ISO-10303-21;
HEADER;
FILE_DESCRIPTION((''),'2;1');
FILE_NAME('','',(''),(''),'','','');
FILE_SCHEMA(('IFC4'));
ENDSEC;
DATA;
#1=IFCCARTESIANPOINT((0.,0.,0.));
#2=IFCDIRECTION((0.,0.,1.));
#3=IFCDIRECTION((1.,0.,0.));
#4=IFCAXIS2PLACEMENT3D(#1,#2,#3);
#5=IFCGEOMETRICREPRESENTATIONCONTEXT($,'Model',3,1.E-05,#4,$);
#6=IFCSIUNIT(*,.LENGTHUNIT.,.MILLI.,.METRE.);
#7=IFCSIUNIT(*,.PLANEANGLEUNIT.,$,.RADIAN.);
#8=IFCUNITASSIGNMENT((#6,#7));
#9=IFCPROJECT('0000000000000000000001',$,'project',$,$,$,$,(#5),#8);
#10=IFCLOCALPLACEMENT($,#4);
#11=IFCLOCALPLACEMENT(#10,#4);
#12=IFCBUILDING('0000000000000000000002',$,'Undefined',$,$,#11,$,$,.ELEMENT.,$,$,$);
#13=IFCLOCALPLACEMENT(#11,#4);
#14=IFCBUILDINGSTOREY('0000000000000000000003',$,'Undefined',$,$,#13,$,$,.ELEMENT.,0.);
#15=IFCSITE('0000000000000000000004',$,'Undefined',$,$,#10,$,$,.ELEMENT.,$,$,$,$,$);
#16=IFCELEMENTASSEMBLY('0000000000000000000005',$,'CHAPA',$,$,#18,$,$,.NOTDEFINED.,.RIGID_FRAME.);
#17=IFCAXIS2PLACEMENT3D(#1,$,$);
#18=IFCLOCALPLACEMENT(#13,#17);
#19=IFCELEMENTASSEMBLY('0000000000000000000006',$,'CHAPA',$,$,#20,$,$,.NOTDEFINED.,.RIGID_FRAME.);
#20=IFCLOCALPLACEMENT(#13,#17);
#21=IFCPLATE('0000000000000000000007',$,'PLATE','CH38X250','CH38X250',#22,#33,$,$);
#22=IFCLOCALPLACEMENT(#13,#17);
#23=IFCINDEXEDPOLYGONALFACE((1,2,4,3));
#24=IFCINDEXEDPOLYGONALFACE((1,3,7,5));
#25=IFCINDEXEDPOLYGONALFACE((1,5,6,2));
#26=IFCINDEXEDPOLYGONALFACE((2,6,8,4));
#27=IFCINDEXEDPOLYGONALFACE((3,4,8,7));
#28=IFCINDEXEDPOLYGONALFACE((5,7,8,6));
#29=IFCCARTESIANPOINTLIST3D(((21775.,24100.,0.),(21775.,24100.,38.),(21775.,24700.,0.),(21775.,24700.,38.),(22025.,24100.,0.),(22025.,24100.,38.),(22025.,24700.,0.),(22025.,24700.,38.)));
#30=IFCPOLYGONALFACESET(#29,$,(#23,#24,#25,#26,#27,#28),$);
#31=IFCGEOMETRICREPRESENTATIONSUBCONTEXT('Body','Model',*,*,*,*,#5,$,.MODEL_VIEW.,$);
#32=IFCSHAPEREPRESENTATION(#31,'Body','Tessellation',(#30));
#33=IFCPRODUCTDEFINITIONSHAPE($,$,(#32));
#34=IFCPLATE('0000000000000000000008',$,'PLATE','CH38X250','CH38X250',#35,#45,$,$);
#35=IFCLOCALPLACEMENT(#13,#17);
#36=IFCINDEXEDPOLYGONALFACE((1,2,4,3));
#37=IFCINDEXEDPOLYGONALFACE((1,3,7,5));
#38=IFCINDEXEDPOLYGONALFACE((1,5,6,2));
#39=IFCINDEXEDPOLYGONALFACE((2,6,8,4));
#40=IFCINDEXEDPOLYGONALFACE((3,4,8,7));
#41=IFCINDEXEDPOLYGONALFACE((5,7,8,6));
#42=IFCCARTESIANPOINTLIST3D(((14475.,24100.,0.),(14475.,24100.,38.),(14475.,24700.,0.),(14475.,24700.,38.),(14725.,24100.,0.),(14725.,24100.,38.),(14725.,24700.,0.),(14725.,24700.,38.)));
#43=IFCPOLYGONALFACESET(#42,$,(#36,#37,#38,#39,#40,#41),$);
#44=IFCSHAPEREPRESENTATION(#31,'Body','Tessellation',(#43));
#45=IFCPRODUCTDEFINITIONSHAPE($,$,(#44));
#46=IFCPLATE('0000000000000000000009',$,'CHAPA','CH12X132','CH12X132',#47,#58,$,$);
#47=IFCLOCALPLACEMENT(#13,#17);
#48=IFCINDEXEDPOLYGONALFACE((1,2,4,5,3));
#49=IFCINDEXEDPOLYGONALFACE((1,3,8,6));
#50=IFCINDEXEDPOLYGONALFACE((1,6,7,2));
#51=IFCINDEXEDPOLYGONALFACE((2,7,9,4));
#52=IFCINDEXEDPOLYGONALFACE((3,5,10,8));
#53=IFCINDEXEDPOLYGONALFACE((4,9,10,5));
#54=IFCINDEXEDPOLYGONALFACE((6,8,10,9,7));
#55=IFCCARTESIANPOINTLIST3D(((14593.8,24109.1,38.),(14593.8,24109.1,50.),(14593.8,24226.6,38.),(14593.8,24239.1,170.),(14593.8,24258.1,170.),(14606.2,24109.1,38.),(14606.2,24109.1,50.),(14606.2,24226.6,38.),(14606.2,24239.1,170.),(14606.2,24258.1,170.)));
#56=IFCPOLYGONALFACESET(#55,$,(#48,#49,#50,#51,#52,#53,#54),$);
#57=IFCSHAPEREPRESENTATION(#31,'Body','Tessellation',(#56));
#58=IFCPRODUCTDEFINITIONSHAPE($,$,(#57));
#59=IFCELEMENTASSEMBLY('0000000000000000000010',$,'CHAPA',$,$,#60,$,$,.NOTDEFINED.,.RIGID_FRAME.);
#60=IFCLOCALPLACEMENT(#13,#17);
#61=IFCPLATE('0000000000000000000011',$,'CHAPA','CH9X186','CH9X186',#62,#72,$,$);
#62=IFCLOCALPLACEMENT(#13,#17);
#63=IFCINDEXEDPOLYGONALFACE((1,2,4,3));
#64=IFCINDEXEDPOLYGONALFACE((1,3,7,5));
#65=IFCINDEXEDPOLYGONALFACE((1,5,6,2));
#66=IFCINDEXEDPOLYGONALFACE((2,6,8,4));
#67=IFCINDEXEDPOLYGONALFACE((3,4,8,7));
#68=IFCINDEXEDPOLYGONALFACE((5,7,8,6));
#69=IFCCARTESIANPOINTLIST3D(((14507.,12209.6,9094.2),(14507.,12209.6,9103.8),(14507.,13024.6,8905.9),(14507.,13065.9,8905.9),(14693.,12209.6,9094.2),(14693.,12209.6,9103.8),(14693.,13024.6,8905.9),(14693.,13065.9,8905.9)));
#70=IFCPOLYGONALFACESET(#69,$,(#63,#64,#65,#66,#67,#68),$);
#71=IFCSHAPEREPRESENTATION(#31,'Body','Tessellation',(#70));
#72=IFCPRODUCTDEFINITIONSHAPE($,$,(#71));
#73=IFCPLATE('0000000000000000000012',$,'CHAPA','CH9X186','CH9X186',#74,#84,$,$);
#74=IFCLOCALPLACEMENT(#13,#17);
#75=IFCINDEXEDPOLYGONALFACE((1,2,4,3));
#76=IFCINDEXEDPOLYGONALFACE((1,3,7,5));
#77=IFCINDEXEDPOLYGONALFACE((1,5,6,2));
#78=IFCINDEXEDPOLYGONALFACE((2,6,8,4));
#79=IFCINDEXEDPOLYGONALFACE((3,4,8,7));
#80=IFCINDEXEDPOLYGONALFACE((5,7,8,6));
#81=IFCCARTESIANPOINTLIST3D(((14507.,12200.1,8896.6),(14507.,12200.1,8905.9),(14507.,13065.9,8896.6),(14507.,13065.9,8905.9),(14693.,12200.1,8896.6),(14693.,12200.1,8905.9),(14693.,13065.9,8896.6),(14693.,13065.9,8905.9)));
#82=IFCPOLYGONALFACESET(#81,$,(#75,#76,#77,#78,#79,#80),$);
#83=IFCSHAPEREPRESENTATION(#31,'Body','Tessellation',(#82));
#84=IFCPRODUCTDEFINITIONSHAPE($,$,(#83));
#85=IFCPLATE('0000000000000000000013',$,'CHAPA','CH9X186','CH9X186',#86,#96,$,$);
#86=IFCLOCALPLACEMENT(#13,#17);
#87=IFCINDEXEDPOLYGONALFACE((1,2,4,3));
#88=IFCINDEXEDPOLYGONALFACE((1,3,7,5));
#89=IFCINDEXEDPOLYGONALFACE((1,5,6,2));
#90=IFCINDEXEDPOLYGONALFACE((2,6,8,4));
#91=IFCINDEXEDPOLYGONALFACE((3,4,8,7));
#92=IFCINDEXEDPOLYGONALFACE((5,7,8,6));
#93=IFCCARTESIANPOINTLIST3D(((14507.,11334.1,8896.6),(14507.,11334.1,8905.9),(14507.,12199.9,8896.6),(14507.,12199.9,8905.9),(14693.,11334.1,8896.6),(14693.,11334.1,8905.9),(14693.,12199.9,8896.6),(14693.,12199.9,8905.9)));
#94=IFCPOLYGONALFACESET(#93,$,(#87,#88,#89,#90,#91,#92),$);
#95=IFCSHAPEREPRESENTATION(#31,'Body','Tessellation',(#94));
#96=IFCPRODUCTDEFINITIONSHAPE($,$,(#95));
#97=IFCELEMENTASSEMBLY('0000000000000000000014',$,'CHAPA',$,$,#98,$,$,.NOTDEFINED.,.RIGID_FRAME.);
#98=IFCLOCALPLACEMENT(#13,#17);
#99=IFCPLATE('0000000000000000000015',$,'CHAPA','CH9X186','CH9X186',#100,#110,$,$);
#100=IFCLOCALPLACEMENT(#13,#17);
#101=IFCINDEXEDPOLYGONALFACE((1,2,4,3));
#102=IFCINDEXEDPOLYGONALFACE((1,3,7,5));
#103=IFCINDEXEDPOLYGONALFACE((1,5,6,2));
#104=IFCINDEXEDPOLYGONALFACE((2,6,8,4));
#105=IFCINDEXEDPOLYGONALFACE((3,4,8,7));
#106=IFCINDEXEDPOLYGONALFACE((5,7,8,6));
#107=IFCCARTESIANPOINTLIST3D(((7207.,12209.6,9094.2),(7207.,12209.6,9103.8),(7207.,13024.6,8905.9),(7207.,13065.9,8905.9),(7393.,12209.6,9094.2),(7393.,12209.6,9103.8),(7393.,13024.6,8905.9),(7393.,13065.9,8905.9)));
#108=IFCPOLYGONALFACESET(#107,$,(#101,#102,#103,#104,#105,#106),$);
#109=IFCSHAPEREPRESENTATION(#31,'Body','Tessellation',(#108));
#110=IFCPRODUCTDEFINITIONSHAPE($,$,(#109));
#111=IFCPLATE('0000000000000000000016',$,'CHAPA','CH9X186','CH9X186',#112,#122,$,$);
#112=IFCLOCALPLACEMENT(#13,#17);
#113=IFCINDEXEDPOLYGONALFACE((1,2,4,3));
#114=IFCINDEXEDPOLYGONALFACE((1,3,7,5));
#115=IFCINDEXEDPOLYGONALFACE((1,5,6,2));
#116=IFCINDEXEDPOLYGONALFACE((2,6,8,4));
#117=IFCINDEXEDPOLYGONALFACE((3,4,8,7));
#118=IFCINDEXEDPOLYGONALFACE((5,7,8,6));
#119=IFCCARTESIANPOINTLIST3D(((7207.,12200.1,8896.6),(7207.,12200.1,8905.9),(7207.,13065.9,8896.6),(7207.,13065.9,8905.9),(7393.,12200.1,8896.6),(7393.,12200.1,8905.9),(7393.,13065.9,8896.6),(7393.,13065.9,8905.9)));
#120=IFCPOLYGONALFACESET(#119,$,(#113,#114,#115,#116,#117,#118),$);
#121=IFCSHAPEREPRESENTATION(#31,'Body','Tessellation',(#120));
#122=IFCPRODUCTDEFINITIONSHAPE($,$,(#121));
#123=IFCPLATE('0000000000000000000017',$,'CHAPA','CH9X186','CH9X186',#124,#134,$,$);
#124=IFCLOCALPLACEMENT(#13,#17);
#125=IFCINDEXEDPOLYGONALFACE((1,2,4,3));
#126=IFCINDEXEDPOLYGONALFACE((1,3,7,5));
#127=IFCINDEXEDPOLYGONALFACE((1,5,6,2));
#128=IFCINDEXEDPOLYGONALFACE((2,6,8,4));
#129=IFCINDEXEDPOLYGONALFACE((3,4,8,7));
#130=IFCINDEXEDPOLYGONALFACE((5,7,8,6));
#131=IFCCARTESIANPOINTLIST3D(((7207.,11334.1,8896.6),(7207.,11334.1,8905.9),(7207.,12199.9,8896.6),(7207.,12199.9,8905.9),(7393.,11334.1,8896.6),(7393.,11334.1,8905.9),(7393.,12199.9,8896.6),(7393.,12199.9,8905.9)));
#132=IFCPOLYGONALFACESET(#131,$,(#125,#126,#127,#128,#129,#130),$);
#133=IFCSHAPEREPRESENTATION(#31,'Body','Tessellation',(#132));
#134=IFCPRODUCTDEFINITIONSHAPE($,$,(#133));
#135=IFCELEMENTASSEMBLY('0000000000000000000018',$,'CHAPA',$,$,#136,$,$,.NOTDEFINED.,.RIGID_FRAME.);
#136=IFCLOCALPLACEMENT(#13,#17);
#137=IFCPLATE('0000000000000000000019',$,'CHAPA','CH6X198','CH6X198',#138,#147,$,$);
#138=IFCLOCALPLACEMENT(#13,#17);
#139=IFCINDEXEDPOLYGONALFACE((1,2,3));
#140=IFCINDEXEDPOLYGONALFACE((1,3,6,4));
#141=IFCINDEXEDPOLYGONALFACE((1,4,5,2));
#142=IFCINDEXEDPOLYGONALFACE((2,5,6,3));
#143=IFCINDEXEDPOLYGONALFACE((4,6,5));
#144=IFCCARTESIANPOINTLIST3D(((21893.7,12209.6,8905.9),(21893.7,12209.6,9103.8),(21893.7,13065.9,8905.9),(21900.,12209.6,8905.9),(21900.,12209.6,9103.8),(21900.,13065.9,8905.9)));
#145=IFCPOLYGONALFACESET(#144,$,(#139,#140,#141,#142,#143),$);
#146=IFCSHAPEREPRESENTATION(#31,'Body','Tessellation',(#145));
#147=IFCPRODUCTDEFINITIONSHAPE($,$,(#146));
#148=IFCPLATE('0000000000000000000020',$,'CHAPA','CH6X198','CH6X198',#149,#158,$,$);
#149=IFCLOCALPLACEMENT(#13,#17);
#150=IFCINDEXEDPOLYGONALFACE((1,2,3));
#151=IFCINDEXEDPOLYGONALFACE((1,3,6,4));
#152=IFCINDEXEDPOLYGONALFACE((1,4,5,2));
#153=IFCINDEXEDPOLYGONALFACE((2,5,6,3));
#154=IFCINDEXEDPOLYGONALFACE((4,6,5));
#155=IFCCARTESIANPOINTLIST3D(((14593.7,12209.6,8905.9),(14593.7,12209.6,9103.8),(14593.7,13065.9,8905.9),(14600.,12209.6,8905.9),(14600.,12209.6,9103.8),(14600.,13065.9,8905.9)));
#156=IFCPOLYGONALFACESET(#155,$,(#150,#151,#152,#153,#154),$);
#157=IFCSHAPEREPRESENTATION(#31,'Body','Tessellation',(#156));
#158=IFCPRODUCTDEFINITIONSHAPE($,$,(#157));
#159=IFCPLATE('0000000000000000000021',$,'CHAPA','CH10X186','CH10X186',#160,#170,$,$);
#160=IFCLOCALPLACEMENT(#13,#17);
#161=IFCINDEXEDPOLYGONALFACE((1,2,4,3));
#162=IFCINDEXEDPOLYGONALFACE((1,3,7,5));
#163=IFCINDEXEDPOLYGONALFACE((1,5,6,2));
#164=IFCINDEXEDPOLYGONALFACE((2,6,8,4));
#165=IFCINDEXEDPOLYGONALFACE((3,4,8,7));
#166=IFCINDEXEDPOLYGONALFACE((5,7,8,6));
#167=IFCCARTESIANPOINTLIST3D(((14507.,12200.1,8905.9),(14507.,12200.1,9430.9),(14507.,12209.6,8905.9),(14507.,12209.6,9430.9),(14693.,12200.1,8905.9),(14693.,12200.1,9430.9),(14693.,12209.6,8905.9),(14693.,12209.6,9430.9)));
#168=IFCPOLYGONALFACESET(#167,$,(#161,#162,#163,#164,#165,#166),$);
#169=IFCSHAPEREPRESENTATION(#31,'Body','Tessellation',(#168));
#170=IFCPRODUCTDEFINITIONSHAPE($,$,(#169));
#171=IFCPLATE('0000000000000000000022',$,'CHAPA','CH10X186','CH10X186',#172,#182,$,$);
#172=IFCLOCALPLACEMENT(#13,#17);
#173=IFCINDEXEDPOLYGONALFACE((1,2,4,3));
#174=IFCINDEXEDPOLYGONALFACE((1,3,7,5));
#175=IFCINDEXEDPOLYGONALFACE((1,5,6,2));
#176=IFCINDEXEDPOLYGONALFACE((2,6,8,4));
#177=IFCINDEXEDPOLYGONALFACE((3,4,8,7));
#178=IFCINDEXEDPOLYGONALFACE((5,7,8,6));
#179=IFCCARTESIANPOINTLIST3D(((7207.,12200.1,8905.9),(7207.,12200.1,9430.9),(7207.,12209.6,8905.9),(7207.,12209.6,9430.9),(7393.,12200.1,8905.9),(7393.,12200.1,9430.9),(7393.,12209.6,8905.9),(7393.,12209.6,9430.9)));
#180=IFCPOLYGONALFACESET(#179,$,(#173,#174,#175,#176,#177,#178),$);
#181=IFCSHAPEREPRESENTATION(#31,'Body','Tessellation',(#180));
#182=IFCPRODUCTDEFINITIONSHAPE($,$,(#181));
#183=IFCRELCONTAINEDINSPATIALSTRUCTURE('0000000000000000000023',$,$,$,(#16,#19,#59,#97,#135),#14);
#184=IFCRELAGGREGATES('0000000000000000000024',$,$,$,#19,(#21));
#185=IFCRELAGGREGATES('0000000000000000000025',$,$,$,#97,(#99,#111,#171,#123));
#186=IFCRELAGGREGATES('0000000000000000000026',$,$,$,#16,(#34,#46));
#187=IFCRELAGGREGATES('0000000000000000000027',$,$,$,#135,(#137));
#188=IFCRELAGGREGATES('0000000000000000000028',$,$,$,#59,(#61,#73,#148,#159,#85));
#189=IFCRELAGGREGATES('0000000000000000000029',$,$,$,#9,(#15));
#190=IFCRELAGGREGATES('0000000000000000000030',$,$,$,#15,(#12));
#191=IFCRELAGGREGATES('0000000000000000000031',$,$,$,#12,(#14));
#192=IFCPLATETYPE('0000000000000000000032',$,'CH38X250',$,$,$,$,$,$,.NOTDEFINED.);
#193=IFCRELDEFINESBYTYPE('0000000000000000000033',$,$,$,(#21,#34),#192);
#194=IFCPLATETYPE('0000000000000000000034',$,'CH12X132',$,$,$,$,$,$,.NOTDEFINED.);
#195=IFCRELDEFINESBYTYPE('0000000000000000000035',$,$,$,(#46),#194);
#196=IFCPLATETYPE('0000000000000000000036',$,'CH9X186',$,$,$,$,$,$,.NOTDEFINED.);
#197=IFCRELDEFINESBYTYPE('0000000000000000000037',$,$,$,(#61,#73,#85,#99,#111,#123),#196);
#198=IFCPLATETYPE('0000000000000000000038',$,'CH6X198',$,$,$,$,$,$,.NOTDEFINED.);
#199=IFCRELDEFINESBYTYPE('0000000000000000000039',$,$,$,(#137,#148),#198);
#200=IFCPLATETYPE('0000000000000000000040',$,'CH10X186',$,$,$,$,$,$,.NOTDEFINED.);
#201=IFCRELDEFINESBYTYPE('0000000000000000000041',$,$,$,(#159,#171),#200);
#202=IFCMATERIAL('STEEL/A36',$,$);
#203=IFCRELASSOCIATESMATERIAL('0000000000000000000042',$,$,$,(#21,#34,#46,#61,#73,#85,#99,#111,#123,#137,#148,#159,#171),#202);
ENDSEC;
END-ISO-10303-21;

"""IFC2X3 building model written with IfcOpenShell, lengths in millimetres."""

from ifc_helpers import new_model, si_unit, frame, origin_with_axes, place, context, subcontext, project, spatial, polyline, outline, extrude, clip, halfspace, material, type_object, element, aggregate, save


model = new_model("IFC2X3")

# Units and contexts
model_context = context("Model", 3, precision=1e-05, world=origin_with_axes())
body_context = subcontext(model_context, "Body", "Model", "MODEL_VIEW")
ifc_project = project(units=[si_unit("LENGTHUNIT", "METRE", prefix="MILLI"), si_unit("PLANEANGLEUNIT", "RADIAN")], contexts=[model_context])

# Site, building, storey
site_placement = place(None, origin_with_axes())
site = spatial("IfcSite", under=ifc_project, at=site_placement, Name="Undefined", CompositionType="ELEMENT")
building_placement = place(site_placement, origin_with_axes())
building = spatial("IfcBuilding", under=site, at=building_placement, Name="Undefined", CompositionType="ELEMENT")
storey_placement = place(building_placement, origin_with_axes())
storey = spatial("IfcBuildingStorey", under=building, at=storey_placement, Name="Undefined", CompositionType="ELEMENT", Elevation=0.0)

# Element assembly
assembly_1_placement = place(storey_placement, origin_with_axes())
assembly_1 = element("IfcElementAssembly", 1, at=assembly_1_placement, inside=storey, Name="CHAPA", AssemblyPlace="NOTDEFINED", PredefinedType="RIGID_FRAME")

# Element assembly, plate
assembly_2_placement = place(storey_placement, origin_with_axes())
assembly_2 = element("IfcElementAssembly", 2, at=assembly_2_placement, inside=storey, Name="CHAPA", AssemblyPlace="NOTDEFINED", PredefinedType="RIGID_FRAME")
ifc_material_1 = material(Name="STEEL/A36")
plate_type_1 = type_object("IfcPlateType", Name="CH38X250", PredefinedType="NOTDEFINED")
plate_1_placement = place(assembly_2_placement, frame((21775.0, 24700.0, 19.0), z_axis=(0.0, 0.0, 1.0), x_axis=(0.0, -1.0, 0.0)))
plate_1 = element("IfcPlate", 3, at=plate_1_placement, type_object=plate_type_1, material=ifc_material_1, Name="PLATE", Description="CH38X250", ObjectType="CH38X250", context=body_context, shape_type="SweptSolid", body=[
    extrude(outline(polyline([(0.0, 0.0), (600.0, 0.0), (600.0, 250.0), (0.0, 250.0), (0.0, 0.0)])), frame((0.0, 0.0, -19.0), z_axis=(0.0, 0.0, 1.0), x_axis=(1.0, 0.0, 0.0)), (0.0, 0.0, 1.0), 38.0),
])
aggregate(assembly_2, [plate_1])

# Plates
plate_2_placement = place(assembly_1_placement, frame((14475.0, 24700.0, 19.0), z_axis=(0.0, 0.0, 1.0), x_axis=(0.0, -1.0, 0.0)))
plate_2 = element("IfcPlate", 4, at=plate_2_placement, type_object=plate_type_1, material=ifc_material_1, Name="PLATE", Description="CH38X250", ObjectType="CH38X250", context=body_context, shape_type="SweptSolid", body=[
    extrude(outline(polyline([(0.0, 0.0), (600.0, 0.0), (600.0, 250.0), (0.0, 250.0), (0.0, 0.0)])), frame((0.0, 0.0, -19.0), z_axis=(0.0, 0.0, 1.0), x_axis=(1.0, 0.0, 0.0)), (0.0, 0.0, 1.0), 38.0),
])
plate_type_2 = type_object("IfcPlateType", Name="CH12X132", PredefinedType="NOTDEFINED")
plate_3_placement = place(assembly_1_placement, frame((14600.0, 24226.6, 38.0), z_axis=(-1.0, 0.0, 0.0), x_axis=(0.0, -1.0, 0.0)))
plate_3 = element("IfcPlate", 5, at=plate_3_placement, type_object=plate_type_2, material=ifc_material_1, Name="CHAPA", Description="CH12X132", ObjectType="CH12X132", context=body_context, shape_type="SweptSolid", body=[
    extrude(outline(polyline([(0.0, 0.0), (117.5, 0.0), (117.5, 12.0), (-12.5, 132.0), (-31.6, 132.0), (0.0, 0.0)])), frame((0.0, 0.0, -6.2), z_axis=(0.0, 0.0, 1.0), x_axis=(1.0, 0.0, 0.0)), (0.0, 0.0, 1.0), 12.5),
])

# Element assemblies, plates
assembly_3_placement = place(storey_placement, origin_with_axes())
assembly_3 = element("IfcElementAssembly", 6, at=assembly_3_placement, inside=storey, Name="CHAPA", AssemblyPlace="NOTDEFINED", PredefinedType="RIGID_FRAME")
plate_type_3 = type_object("IfcPlateType", Name="CH9X186", PredefinedType="NOTDEFINED")
plate_4_placement = place(assembly_3_placement, frame((14693.0, 12208.6, 9099.3), z_axis=(0.0, -0.225125, -0.97433), x_axis=(-1.0, 0.0, 0.0)))
plate_4 = element("IfcPlate", 7, at=plate_4_placement, type_object=plate_type_3, material=ifc_material_1, Name="CHAPA", Description="CH9X186", ObjectType="CH9X186", context=body_context, shape_type="Clipping", body=[
    clip(clip(extrude(outline(polyline([(0.0, 0.0), (186.0, 0.0), (186.0, 878.9), (0.0, 878.9), (0.0, 0.0)])), frame((0.0, 0.0, -4.7), z_axis=(0.0, 0.0, 1.0), x_axis=(1.0, 0.0, 0.0)), (0.0, 0.0, 1.0), 9.3), halfspace(frame((186.0, -500.0, 314.0), z_axis=(0.0, 0.225128, 0.974329), x_axis=(-1.0, 0.0, 0.0)), False)), halfspace(frame((0.0, 2.1, 4.7), z_axis=(0.0, -0.97433, 0.225125), x_axis=(1.0, 0.0, 0.0)), False)),
])
plate_5_placement = place(assembly_3_placement, frame((14693.0, 12200.1, 8901.3), z_axis=(0.0, 0.0, -1.0), x_axis=(-1.0, 0.0, 0.0)))
plate_5 = element("IfcPlate", 8, at=plate_5_placement, type_object=plate_type_3, material=ifc_material_1, Name="CHAPA", Description="CH9X186", ObjectType="CH9X186", context=body_context, shape_type="SweptSolid", body=[
    extrude(outline(polyline([(0.0, 0.0), (186.0, 0.0), (186.0, 865.8), (0.0, 865.8), (0.0, 0.0)])), frame((0.0, 0.0, -4.7), z_axis=(0.0, 0.0, 1.0), x_axis=(1.0, 0.0, 0.0)), (0.0, 0.0, 1.0), 9.3),
])
plate_6_placement = place(assembly_3_placement, frame((14693.0, 12199.9, 8901.3), z_axis=(0.0, 0.0, 1.0), x_axis=(-1.0, 0.0, 0.0)))
plate_6 = element("IfcPlate", 9, at=plate_6_placement, type_object=plate_type_3, material=ifc_material_1, Name="CHAPA", Description="CH9X186", ObjectType="CH9X186", context=body_context, shape_type="SweptSolid", body=[
    extrude(outline(polyline([(0.0, 0.0), (186.0, 0.0), (186.0, 865.8), (0.0, 865.8), (0.0, 0.0)])), frame((0.0, 0.0, -4.7), z_axis=(0.0, 0.0, 1.0), x_axis=(1.0, 0.0, 0.0)), (0.0, 0.0, 1.0), 9.3),
])
assembly_4_placement = place(storey_placement, origin_with_axes())
assembly_4 = element("IfcElementAssembly", 10, at=assembly_4_placement, inside=storey, Name="CHAPA", AssemblyPlace="NOTDEFINED", PredefinedType="RIGID_FRAME")
plate_7_placement = place(assembly_4_placement, frame((7393.0, 12208.6, 9099.3), z_axis=(0.0, -0.225125, -0.97433), x_axis=(-1.0, 0.0, 0.0)))
plate_7 = element("IfcPlate", 11, at=plate_7_placement, type_object=plate_type_3, material=ifc_material_1, Name="CHAPA", Description="CH9X186", ObjectType="CH9X186", context=body_context, shape_type="Clipping", body=[
    clip(clip(extrude(outline(polyline([(0.0, 0.0), (186.0, 0.0), (186.0, 878.9), (0.0, 878.9), (0.0, 0.0)])), frame((0.0, 0.0, -4.7), z_axis=(0.0, 0.0, 1.0), x_axis=(1.0, 0.0, 0.0)), (0.0, 0.0, 1.0), 9.3), halfspace(frame((186.0, -500.0, 314.0), z_axis=(0.0, 0.225128, 0.974329), x_axis=(-1.0, 0.0, 0.0)), False)), halfspace(frame((0.0, 2.1, 4.7), z_axis=(0.0, -0.97433, 0.225125), x_axis=(1.0, 0.0, 0.0)), False)),
])
plate_8_placement = place(assembly_4_placement, frame((7393.0, 12200.1, 8901.3), z_axis=(0.0, 0.0, -1.0), x_axis=(-1.0, 0.0, 0.0)))
plate_8 = element("IfcPlate", 12, at=plate_8_placement, type_object=plate_type_3, material=ifc_material_1, Name="CHAPA", Description="CH9X186", ObjectType="CH9X186", context=body_context, shape_type="SweptSolid", body=[
    extrude(outline(polyline([(0.0, 0.0), (186.0, 0.0), (186.0, 865.8), (0.0, 865.8), (0.0, 0.0)])), frame((0.0, 0.0, -4.7), z_axis=(0.0, 0.0, 1.0), x_axis=(1.0, 0.0, 0.0)), (0.0, 0.0, 1.0), 9.3),
])
plate_9_placement = place(assembly_4_placement, frame((7393.0, 12199.9, 8901.3), z_axis=(0.0, 0.0, 1.0), x_axis=(-1.0, 0.0, 0.0)))
plate_9 = element("IfcPlate", 13, at=plate_9_placement, type_object=plate_type_3, material=ifc_material_1, Name="CHAPA", Description="CH9X186", ObjectType="CH9X186", context=body_context, shape_type="SweptSolid", body=[
    extrude(outline(polyline([(0.0, 0.0), (186.0, 0.0), (186.0, 865.8), (0.0, 865.8), (0.0, 0.0)])), frame((0.0, 0.0, -4.7), z_axis=(0.0, 0.0, 1.0), x_axis=(1.0, 0.0, 0.0)), (0.0, 0.0, 1.0), 9.3),
])

# Element assembly, plate
assembly_5_placement = place(storey_placement, origin_with_axes())
assembly_5 = element("IfcElementAssembly", 14, at=assembly_5_placement, inside=storey, Name="CHAPA", AssemblyPlace="NOTDEFINED", PredefinedType="RIGID_FRAME")
plate_type_4 = type_object("IfcPlateType", Name="CH6X198", PredefinedType="NOTDEFINED")
plate_10_placement = place(assembly_5_placement, frame((21896.8, 13065.9, 8905.9), z_axis=(-1.0, 0.0, 0.0), x_axis=(0.0, -1.0, 0.0)))
plate_10 = element("IfcPlate", 15, at=plate_10_placement, type_object=plate_type_4, material=ifc_material_1, Name="CHAPA", Description="CH6X198", ObjectType="CH6X198", context=body_context, shape_type="SweptSolid", body=[
    extrude(outline(polyline([(0.0, 0.0), (856.3, 0.0), (856.3, 197.9), (0.0, 0.0)])), frame((0.0, 0.0, -3.1), z_axis=(0.0, 0.0, 1.0), x_axis=(1.0, 0.0, 0.0)), (0.0, 0.0, 1.0), 6.3),
])

# Plates
plate_11_placement = place(assembly_3_placement, frame((14596.9, 13065.9, 8905.9), z_axis=(-1.0, 0.0, 0.0), x_axis=(0.0, -1.0, 0.0)))
plate_11 = element("IfcPlate", 16, at=plate_11_placement, type_object=plate_type_4, material=ifc_material_1, Name="CHAPA", Description="CH6X198", ObjectType="CH6X198", context=body_context, shape_type="SweptSolid", body=[
    extrude(outline(polyline([(0.0, 0.0), (856.3, 0.0), (856.3, 197.9), (0.0, 0.0)])), frame((0.0, 0.0, -3.1), z_axis=(0.0, 0.0, 1.0), x_axis=(1.0, 0.0, 0.0)), (0.0, 0.0, 1.0), 6.3),
])
plate_type_5 = type_object("IfcPlateType", Name="CH10X186", PredefinedType="NOTDEFINED")
plate_12_placement = place(assembly_3_placement, frame((14693.0, 12204.8, 9430.9), z_axis=(0.0, -1.0, 0.0), x_axis=(-1.0, 0.0, 0.0)))
plate_12 = element("IfcPlate", 17, at=plate_12_placement, type_object=plate_type_5, material=ifc_material_1, Name="CHAPA", Description="CH10X186", ObjectType="CH10X186", context=body_context, shape_type="SweptSolid", body=[
    extrude(outline(polyline([(0.0, 0.0), (186.0, 0.0), (186.0, 525.0), (0.0, 525.0), (0.0, 0.0)])), frame((0.0, 0.0, -4.8), z_axis=(0.0, 0.0, 1.0), x_axis=(1.0, 0.0, 0.0)), (0.0, 0.0, 1.0), 9.5),
])
plate_13_placement = place(assembly_4_placement, frame((7393.0, 12204.8, 9430.9), z_axis=(0.0, -1.0, 0.0), x_axis=(-1.0, 0.0, 0.0)))
plate_13 = element("IfcPlate", 18, at=plate_13_placement, type_object=plate_type_5, material=ifc_material_1, Name="CHAPA", Description="CH10X186", ObjectType="CH10X186", context=body_context, shape_type="SweptSolid", body=[
    extrude(outline(polyline([(0.0, 0.0), (186.0, 0.0), (186.0, 525.0), (0.0, 525.0), (0.0, 0.0)])), frame((0.0, 0.0, -4.8), z_axis=(0.0, 0.0, 1.0), x_axis=(1.0, 0.0, 0.0)), (0.0, 0.0, 1.0), 9.5),
])
aggregate(assembly_4, [plate_7, plate_8, plate_13, plate_9])

aggregate(assembly_1, [plate_2, plate_3])
aggregate(assembly_5, [plate_10])
aggregate(assembly_3, [plate_4, plate_5, plate_11, plate_12, plate_6])

save(model, "model.ifc")
